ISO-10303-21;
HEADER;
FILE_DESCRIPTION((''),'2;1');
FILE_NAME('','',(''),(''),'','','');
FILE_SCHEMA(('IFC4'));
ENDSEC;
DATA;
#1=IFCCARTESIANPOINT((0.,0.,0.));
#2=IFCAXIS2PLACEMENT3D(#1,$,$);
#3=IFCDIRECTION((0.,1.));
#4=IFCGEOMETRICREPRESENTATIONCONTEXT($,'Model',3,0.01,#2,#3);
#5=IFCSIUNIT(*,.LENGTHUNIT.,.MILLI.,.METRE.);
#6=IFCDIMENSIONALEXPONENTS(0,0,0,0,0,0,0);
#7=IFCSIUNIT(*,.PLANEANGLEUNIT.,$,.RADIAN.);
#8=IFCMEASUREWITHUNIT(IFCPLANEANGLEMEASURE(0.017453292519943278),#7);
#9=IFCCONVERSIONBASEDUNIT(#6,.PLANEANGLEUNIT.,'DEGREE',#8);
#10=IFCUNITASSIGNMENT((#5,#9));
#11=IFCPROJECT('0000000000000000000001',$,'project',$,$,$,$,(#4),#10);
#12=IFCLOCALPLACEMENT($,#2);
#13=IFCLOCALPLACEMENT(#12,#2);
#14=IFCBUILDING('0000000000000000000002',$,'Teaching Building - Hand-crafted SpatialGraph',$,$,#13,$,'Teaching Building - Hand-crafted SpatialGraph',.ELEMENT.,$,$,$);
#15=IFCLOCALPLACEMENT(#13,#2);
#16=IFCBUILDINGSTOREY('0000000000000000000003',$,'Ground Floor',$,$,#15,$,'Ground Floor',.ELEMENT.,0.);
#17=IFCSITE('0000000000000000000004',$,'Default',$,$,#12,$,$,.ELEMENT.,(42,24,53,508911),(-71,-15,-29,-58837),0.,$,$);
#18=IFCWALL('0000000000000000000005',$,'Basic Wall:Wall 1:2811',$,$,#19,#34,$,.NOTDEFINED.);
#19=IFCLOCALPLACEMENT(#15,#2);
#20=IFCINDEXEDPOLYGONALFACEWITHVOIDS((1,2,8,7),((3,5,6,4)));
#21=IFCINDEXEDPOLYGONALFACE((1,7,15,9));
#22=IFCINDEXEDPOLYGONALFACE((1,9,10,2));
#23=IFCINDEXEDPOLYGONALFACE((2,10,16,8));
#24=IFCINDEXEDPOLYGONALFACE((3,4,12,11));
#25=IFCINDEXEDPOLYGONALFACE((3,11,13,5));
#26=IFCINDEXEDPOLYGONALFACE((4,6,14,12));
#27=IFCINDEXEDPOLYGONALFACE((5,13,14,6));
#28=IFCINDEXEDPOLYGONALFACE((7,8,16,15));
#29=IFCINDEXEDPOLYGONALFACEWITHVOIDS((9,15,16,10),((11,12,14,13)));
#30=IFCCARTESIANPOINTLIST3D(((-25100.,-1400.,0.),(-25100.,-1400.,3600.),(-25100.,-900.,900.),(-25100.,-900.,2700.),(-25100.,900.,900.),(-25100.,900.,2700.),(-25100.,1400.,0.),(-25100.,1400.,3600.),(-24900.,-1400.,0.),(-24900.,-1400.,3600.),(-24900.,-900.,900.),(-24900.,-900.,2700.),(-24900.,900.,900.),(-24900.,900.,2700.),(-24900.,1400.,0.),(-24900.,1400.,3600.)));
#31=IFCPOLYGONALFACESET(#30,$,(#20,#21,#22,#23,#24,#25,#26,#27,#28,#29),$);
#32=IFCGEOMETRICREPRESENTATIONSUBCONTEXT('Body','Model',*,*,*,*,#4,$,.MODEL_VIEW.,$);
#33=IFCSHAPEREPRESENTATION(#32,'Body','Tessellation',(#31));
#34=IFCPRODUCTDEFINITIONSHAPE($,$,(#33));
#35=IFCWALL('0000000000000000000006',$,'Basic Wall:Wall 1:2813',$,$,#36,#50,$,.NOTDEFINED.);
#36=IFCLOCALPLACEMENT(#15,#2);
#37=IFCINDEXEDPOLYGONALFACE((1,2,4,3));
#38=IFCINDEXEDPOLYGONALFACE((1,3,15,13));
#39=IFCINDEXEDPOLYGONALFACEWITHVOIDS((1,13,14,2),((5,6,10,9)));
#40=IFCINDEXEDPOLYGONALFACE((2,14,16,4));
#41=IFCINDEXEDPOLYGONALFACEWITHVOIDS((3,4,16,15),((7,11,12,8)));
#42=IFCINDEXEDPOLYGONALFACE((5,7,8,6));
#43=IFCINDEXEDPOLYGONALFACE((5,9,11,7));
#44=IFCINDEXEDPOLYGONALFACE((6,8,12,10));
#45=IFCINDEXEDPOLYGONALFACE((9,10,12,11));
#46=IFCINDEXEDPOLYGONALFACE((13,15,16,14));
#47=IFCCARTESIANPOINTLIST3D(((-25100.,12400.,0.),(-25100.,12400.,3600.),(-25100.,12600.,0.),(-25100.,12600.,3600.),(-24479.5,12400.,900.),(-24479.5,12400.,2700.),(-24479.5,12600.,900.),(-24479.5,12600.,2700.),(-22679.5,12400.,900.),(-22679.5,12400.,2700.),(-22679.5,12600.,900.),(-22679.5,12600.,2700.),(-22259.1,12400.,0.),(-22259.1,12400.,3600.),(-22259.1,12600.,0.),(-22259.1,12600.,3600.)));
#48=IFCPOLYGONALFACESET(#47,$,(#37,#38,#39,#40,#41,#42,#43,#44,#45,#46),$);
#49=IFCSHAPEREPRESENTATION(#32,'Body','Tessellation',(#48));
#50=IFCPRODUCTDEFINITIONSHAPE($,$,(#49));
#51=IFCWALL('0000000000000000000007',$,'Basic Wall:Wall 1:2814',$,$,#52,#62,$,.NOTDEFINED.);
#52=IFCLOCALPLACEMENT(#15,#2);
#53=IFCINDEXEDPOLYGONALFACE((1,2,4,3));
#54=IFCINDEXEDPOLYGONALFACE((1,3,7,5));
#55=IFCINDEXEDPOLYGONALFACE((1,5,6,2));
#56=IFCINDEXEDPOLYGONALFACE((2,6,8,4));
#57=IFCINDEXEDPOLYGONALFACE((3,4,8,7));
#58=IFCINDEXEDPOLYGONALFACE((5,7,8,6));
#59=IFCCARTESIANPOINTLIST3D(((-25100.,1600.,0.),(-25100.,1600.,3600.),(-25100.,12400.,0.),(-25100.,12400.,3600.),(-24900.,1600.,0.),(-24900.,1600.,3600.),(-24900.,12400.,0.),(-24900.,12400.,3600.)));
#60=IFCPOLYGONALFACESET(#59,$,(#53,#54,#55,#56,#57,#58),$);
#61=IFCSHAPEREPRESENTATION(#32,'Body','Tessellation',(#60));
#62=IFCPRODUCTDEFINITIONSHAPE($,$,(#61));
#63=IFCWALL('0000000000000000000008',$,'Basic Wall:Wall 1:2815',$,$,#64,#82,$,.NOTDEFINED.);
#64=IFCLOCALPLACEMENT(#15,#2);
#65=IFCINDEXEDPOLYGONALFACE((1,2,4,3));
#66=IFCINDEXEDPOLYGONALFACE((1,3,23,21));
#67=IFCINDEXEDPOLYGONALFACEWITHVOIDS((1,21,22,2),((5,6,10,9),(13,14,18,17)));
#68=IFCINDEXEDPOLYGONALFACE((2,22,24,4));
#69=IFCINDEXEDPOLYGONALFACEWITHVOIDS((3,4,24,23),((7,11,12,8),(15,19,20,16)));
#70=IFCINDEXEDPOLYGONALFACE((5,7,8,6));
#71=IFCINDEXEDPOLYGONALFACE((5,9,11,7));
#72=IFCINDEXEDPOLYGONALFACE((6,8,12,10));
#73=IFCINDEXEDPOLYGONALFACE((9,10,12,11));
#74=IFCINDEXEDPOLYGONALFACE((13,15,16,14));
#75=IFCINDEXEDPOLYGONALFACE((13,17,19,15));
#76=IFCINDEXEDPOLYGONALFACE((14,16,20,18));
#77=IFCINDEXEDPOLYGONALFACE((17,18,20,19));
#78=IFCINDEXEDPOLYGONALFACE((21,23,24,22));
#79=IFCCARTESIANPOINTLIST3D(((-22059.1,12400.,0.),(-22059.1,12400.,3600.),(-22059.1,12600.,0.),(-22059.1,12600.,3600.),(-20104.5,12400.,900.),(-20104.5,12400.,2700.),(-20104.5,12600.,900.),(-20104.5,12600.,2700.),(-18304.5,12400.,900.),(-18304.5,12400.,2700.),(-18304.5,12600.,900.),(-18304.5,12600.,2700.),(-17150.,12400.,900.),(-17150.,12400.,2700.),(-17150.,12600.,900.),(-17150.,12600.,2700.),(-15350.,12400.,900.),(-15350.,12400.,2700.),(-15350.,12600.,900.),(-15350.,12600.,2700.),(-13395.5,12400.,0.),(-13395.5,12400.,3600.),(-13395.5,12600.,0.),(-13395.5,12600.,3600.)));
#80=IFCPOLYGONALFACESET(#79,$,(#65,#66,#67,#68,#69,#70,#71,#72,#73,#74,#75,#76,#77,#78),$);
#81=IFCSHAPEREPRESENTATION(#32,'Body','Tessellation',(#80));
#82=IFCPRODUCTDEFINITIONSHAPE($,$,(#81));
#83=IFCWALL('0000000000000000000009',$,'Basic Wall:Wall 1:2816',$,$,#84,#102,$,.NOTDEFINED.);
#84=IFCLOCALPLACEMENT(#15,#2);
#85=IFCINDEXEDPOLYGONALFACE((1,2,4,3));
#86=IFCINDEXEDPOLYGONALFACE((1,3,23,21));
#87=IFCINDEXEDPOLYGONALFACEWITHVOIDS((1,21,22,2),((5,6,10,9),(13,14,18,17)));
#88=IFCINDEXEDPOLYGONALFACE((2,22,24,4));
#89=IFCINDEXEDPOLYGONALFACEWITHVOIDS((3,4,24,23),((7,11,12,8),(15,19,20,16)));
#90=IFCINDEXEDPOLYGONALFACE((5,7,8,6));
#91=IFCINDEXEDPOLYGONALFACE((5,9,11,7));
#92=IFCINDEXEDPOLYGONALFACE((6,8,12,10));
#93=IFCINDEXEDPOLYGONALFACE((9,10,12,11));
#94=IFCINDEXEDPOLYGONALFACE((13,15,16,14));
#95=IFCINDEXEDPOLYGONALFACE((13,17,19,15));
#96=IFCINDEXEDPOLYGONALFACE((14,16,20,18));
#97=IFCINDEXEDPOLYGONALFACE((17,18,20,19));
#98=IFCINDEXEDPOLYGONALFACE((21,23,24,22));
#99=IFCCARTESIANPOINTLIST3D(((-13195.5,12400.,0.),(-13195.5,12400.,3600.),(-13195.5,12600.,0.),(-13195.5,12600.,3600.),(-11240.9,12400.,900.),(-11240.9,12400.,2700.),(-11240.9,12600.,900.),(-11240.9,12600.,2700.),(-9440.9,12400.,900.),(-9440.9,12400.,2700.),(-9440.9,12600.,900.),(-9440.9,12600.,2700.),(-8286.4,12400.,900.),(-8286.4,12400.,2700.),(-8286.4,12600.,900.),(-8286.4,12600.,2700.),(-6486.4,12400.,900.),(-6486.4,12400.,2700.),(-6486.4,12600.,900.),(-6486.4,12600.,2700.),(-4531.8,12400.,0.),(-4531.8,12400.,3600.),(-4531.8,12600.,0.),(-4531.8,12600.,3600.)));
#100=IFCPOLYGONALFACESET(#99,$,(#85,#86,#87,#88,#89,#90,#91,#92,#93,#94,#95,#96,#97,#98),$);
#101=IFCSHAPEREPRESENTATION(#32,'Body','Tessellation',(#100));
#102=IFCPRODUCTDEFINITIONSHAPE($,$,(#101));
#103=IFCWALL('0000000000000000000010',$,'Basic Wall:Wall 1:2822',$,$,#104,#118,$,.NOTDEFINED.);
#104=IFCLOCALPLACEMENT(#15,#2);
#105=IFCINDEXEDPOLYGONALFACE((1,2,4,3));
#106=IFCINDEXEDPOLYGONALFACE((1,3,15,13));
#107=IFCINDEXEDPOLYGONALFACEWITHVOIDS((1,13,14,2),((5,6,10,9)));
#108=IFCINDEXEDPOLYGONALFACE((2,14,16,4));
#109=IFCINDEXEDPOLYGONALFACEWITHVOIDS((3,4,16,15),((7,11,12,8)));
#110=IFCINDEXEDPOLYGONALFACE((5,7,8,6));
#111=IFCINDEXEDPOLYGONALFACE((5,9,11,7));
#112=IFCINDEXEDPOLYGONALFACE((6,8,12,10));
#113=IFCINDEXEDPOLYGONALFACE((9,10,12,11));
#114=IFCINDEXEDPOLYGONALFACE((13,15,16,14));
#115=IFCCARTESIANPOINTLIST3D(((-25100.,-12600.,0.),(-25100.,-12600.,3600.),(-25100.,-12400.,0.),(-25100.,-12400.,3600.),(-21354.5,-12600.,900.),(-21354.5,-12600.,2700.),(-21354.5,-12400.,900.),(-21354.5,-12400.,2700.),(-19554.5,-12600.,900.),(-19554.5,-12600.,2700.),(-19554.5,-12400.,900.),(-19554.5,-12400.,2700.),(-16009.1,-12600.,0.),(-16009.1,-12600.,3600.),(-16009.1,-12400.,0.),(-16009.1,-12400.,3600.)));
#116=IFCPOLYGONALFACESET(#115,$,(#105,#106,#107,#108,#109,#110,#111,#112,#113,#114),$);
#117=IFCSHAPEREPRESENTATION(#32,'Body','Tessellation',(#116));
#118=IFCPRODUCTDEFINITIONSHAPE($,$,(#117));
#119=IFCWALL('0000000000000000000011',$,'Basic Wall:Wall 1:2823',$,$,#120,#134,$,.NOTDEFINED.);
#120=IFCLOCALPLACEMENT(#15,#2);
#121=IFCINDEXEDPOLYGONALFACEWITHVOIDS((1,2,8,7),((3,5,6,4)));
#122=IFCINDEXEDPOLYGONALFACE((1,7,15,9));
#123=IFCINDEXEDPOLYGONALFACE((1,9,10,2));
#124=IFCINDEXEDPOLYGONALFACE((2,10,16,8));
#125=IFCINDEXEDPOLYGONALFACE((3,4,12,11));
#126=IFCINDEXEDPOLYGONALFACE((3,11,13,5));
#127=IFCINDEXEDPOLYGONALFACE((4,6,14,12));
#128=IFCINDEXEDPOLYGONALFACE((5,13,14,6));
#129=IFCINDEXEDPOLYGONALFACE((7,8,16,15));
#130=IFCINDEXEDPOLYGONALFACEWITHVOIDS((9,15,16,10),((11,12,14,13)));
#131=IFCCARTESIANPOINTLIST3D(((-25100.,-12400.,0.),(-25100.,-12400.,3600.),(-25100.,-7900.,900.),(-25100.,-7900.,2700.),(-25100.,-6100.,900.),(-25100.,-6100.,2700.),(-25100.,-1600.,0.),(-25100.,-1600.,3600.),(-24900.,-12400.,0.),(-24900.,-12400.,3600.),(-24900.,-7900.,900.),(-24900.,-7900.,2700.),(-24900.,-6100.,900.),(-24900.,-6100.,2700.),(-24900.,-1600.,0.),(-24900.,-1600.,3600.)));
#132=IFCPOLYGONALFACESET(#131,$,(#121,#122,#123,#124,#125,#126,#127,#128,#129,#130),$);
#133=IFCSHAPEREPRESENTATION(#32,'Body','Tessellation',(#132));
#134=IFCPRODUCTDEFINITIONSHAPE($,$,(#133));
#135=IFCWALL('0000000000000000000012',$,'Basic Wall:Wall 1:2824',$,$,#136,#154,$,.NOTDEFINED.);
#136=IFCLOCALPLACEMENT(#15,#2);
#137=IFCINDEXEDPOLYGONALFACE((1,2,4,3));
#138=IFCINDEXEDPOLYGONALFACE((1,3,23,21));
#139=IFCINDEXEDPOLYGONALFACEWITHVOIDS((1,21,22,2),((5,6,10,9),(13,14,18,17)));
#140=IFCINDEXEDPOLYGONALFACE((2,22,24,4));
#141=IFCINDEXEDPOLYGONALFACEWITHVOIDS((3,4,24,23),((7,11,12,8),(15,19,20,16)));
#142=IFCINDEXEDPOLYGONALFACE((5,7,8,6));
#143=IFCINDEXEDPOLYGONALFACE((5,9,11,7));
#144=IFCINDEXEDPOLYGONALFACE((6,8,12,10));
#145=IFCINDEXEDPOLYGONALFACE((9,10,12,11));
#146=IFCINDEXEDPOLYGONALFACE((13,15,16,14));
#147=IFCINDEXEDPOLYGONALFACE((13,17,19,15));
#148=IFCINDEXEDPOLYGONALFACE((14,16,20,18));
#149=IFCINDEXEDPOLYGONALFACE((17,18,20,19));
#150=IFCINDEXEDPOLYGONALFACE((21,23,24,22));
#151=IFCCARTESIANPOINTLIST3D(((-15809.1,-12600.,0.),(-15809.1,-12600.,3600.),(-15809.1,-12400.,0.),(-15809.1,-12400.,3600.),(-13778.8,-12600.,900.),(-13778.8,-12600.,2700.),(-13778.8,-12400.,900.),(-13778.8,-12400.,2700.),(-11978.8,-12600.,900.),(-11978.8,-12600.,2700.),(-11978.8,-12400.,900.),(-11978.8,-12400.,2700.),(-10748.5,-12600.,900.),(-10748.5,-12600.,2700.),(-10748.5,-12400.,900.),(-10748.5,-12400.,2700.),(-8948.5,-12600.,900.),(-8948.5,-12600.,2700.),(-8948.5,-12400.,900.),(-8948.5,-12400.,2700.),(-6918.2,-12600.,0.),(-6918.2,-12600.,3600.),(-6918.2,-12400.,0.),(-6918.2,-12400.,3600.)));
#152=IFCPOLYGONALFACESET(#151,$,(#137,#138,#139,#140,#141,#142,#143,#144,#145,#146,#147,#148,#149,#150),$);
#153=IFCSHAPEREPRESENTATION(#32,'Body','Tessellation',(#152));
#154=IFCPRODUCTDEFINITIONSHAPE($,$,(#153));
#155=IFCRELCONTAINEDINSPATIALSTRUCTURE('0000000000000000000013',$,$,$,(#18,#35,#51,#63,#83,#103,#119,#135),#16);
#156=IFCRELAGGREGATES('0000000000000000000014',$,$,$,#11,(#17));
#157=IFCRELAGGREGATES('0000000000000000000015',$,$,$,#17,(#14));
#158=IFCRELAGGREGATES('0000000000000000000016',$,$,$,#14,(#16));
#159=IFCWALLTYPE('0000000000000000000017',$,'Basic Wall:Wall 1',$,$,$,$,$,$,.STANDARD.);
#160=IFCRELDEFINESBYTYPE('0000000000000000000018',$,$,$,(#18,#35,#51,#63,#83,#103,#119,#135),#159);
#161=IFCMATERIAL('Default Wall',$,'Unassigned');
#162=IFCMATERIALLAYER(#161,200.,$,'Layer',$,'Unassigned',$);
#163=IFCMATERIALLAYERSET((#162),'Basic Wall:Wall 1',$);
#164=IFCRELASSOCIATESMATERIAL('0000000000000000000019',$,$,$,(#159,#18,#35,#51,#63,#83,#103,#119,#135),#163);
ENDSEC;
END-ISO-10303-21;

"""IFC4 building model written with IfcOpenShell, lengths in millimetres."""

from ifc_helpers import new_model, entity, si_unit, converted_unit, direction, frame, frame_2d, origin, origin_2d_with_axis, place, context, subcontext, project, spatial, rectangle, extrude, material, layer, layer_set, layer_usage, type_object, element, save


model = new_model("IFC4")

# Units and contexts
model_context = context("Model", 3, precision=0.01, world=origin(), true_north=direction((0.0, 1.0)))
body_context = subcontext(model_context, "Body", "Model", "MODEL_VIEW")
ifc_project = project(units=[si_unit("LENGTHUNIT", "METRE", prefix="MILLI"), converted_unit("PLANEANGLEUNIT", "DEGREE", entity("IfcPlaneAngleMeasure", 0.017453292519943278), si_unit("PLANEANGLEUNIT", "RADIAN"), dimensions=[0, 0, 0, 0, 0, 0, 0])], contexts=[model_context])

# Site, building, storey
site_placement = place(None, origin())
site = spatial("IfcSite", under=ifc_project, at=site_placement, Name="Default", CompositionType="ELEMENT", RefLatitude=(42, 24, 53, 508911), RefLongitude=(-71, -15, -29, -58837), RefElevation=0.0)
building_placement = place(site_placement, origin())
building = spatial("IfcBuilding", under=site, at=building_placement, Name="Teaching Building - Hand-crafted SpatialGraph", LongName="Teaching Building - Hand-crafted SpatialGraph", CompositionType="ELEMENT")
storey_placement = place(building_placement, origin())
storey = spatial("IfcBuildingStorey", under=building, at=storey_placement, Name="Ground Floor", LongName="Ground Floor", CompositionType="ELEMENT", Elevation=0.0)

# Shared definitions
ifc_material = material(Name="Default Wall", Category="Unassigned")
ifc_layer = layer(ifc_material, 200.0, Name="Layer", Category="Unassigned")
ifc_layer_set = layer_set([ifc_layer], Name="Basic Wall:Wall 1")
wall_type = type_object("IfcWallType", Name="Basic Wall:Wall 1", PredefinedType="STANDARD", material=ifc_layer_set)

# Walls, openings
ifc_layer_usage_1 = layer_usage(ifc_layer_set, "AXIS2", "NEGATIVE", 100.0)
wall_1_placement = place(storey_placement, frame((-25000.0, -1400.0, 0.0), z_axis=(0.0, 0.0, 1.0), x_axis=(0.0, 1.0, 0.0)))
wall_1 = element("IfcWall", 1, at=wall_1_placement, inside=storey, type_object=wall_type, material=ifc_layer_usage_1, Name="Basic Wall:Wall 1:2811", PredefinedType="NOTDEFINED", context=body_context, shape_type="SweptSolid", body=[
    extrude(rectangle(XDim=2800.0, YDim=200.0, at=frame_2d((1400.0, 0.0), x_axis=(-1.0, 0.0))), origin(), (0.0, 0.0, 1.0), 3600.0),
])
opening_1_placement = place(wall_1_placement, origin())
element("IfcOpeningElement", 2, at=opening_1_placement, cuts=wall_1, PredefinedType="OPENING", context=body_context, shape_type="SweptSolid", body=[
    extrude(rectangle(XDim=1800.0, YDim=1800.0, at=origin_2d_with_axis()), frame((1400.0, -100.0, 1800.0), z_axis=(0.0, 1.0, 0.0), x_axis=(0.0, 0.0, -1.0)), (0.0, 0.0, 1.0), 200.0),
])
ifc_layer_usage_2 = layer_usage(ifc_layer_set, "AXIS2", "NEGATIVE", 100.0)
wall_2_placement = place(storey_placement, frame((-25100.0, 12500.0, 0.0)))
wall_2 = element("IfcWall", 3, at=wall_2_placement, inside=storey, type_object=wall_type, material=ifc_layer_usage_2, Name="Basic Wall:Wall 1:2813", PredefinedType="NOTDEFINED", context=body_context, shape_type="SweptSolid", body=[
    extrude(rectangle(XDim=2840.9, YDim=200.0, at=frame_2d((1420.5, 0.0), x_axis=(-1.0, 0.0))), origin(), (0.0, 0.0, 1.0), 3600.0),
])
opening_2_placement = place(wall_2_placement, origin())
element("IfcOpeningElement", 4, at=opening_2_placement, cuts=wall_2, PredefinedType="OPENING", context=body_context, shape_type="SweptSolid", body=[
    extrude(rectangle(XDim=1800.0, YDim=1800.0, at=frame_2d((0.0, 0.0), x_axis=(1.0, 0.0))), frame((1520.5, -100.0, 1800.0), z_axis=(0.0, 1.0, 0.0), x_axis=(0.0, 0.0, -1.0)), (0.0, 0.0, 1.0), 200.0),
])

# Wall
ifc_layer_usage_3 = layer_usage(ifc_layer_set, "AXIS2", "NEGATIVE", 100.0)
wall_3_placement = place(storey_placement, frame((-25000.0, 1600.0, 0.0), z_axis=(0.0, 0.0, 1.0), x_axis=(0.0, 1.0, 0.0)))
element("IfcWall", 5, at=wall_3_placement, inside=storey, type_object=wall_type, material=ifc_layer_usage_3, Name="Basic Wall:Wall 1:2814", PredefinedType="NOTDEFINED", context=body_context, shape_type="SweptSolid", body=[
    extrude(rectangle(XDim=10800.0, YDim=200.0, at=frame_2d((5400.0, 0.0), x_axis=(-1.0, 0.0))), origin(), (0.0, 0.0, 1.0), 3600.0),
])

# Walls, openings
ifc_layer_usage_4 = layer_usage(ifc_layer_set, "AXIS2", "NEGATIVE", 100.0)
wall_4_placement = place(storey_placement, frame((-22059.1, 12500.0, 0.0)))
wall_4 = element("IfcWall", 6, at=wall_4_placement, inside=storey, type_object=wall_type, material=ifc_layer_usage_4, Name="Basic Wall:Wall 1:2815", PredefinedType="NOTDEFINED", context=body_context, shape_type="SweptSolid", body=[
    extrude(rectangle(XDim=8663.6, YDim=200.0, at=frame_2d((4331.8, 0.0), x_axis=(-1.0, 0.0))), origin(), (0.0, 0.0, 1.0), 3600.0),
])
opening_3_placement = place(wall_4_placement, origin())
element("IfcOpeningElement", 7, at=opening_3_placement, cuts=wall_4, PredefinedType="OPENING", context=body_context, shape_type="SweptSolid", body=[
    extrude(rectangle(XDim=1800.0, YDim=1800.0, at=origin_2d_with_axis()), frame((2854.5, -100.0, 1800.0), z_axis=(0.0, 1.0, 0.0), x_axis=(0.0, 0.0, -1.0)), (0.0, 0.0, 1.0), 200.0),
])
opening_4_placement = place(wall_4_placement, origin())
element("IfcOpeningElement", 8, at=opening_4_placement, cuts=wall_4, PredefinedType="OPENING", context=body_context, shape_type="SweptSolid", body=[
    extrude(rectangle(XDim=1800.0, YDim=1800.0, at=frame_2d((0.0, 0.0), x_axis=(1.0, 0.0))), frame((5809.1, -100.0, 1800.0), z_axis=(0.0, 1.0, 0.0), x_axis=(0.0, 0.0, -1.0)), (0.0, 0.0, 1.0), 200.0),
])
ifc_layer_usage_5 = layer_usage(ifc_layer_set, "AXIS2", "NEGATIVE", 100.0)
wall_5_placement = place(storey_placement, frame((-13195.5, 12500.0, 0.0)))
wall_5 = element("IfcWall", 9, at=wall_5_placement, inside=storey, type_object=wall_type, material=ifc_layer_usage_5, Name="Basic Wall:Wall 1:2816", PredefinedType="NOTDEFINED", context=body_context, shape_type="SweptSolid", body=[
    extrude(rectangle(XDim=8663.6, YDim=200.0, at=frame_2d((4331.8, 0.0), x_axis=(-1.0, 0.0))), origin(), (0.0, 0.0, 1.0), 3600.0),
])
opening_5_placement = place(wall_5_placement, origin())
element("IfcOpeningElement", 10, at=opening_5_placement, cuts=wall_5, PredefinedType="OPENING", context=body_context, shape_type="SweptSolid", body=[
    extrude(rectangle(XDim=1800.0, YDim=1800.0, at=frame_2d((0.0, 0.0), x_axis=(1.0, 0.0))), frame((2854.5, -100.0, 1800.0), z_axis=(0.0, 1.0, 0.0), x_axis=(0.0, 0.0, -1.0)), (0.0, 0.0, 1.0), 200.0),
])
opening_6_placement = place(wall_5_placement, origin())
element("IfcOpeningElement", 11, at=opening_6_placement, cuts=wall_5, PredefinedType="OPENING", context=body_context, shape_type="SweptSolid", body=[
    extrude(rectangle(XDim=1800.0, YDim=1800.0, at=origin_2d_with_axis()), frame((5809.1, -100.0, 1800.0), z_axis=(0.0, 1.0, 0.0), x_axis=(0.0, 0.0, -1.0)), (0.0, 0.0, 1.0), 200.0),
])

# Walls, openings
ifc_layer_usage_6 = layer_usage(ifc_layer_set, "AXIS2", "NEGATIVE", 100.0)
wall_6_placement = place(storey_placement, frame((-25100.0, -12500.0, 0.0)))
wall_6 = element("IfcWall", 12, at=wall_6_placement, inside=storey, type_object=wall_type, material=ifc_layer_usage_6, Name="Basic Wall:Wall 1:2822", PredefinedType="NOTDEFINED", context=body_context, shape_type="SweptSolid", body=[
    extrude(rectangle(XDim=9090.9, YDim=200.0, at=frame_2d((4545.5, 0.0), x_axis=(-1.0, 0.0))), origin(), (0.0, 0.0, 1.0), 3600.0),
])
opening_7_placement = place(wall_6_placement, origin())
element("IfcOpeningElement", 13, at=opening_7_placement, cuts=wall_6, PredefinedType="OPENING", context=body_context, shape_type="SweptSolid", body=[
    extrude(rectangle(XDim=1800.0, YDim=1800.0, at=frame_2d((0.0, 0.0), x_axis=(1.0, 0.0))), frame((4645.5, -100.0, 1800.0), z_axis=(0.0, 1.0, 0.0), x_axis=(0.0, 0.0, -1.0)), (0.0, 0.0, 1.0), 200.0),
])
ifc_layer_usage_7 = layer_usage(ifc_layer_set, "AXIS2", "NEGATIVE", 100.0)
wall_7_placement = place(storey_placement, frame((-25000.0, -12400.0, 0.0), z_axis=(0.0, 0.0, 1.0), x_axis=(0.0, 1.0, 0.0)))
wall_7 = element("IfcWall", 14, at=wall_7_placement, inside=storey, type_object=wall_type, material=ifc_layer_usage_7, Name="Basic Wall:Wall 1:2823", PredefinedType="NOTDEFINED", context=body_context, shape_type="SweptSolid", body=[
    extrude(rectangle(XDim=10800.0, YDim=200.0, at=frame_2d((5400.0, 0.0), x_axis=(-1.0, 0.0))), origin(), (0.0, 0.0, 1.0), 3600.0),
])
opening_8_placement = place(wall_7_placement, origin())
element("IfcOpeningElement", 15, at=opening_8_placement, cuts=wall_7, PredefinedType="OPENING", context=body_context, shape_type="SweptSolid", body=[
    extrude(rectangle(XDim=1800.0, YDim=1800.0, at=origin_2d_with_axis()), frame((5400.0, -100.0, 1800.0), z_axis=(0.0, 1.0, 0.0), x_axis=(0.0, 0.0, -1.0)), (0.0, 0.0, 1.0), 200.0),
])

# Wall, openings
ifc_layer_usage_8 = layer_usage(ifc_layer_set, "AXIS2", "NEGATIVE", 100.0)
wall_8_placement = place(storey_placement, frame((-15809.1, -12500.0, 0.0)))
wall_8 = element("IfcWall", 16, at=wall_8_placement, inside=storey, type_object=wall_type, material=ifc_layer_usage_8, Name="Basic Wall:Wall 1:2824", PredefinedType="NOTDEFINED", context=body_context, shape_type="SweptSolid", body=[
    extrude(rectangle(XDim=8890.9, YDim=200.0, at=frame_2d((4445.5, 0.0), x_axis=(-1.0, 0.0))), origin(), (0.0, 0.0, 1.0), 3600.0),
])
opening_9_placement = place(wall_8_placement, origin())
element("IfcOpeningElement", 17, at=opening_9_placement, cuts=wall_8, PredefinedType="OPENING", context=body_context, shape_type="SweptSolid", body=[
    extrude(rectangle(XDim=1800.0, YDim=1800.0, at=frame_2d((0.0, 0.0), x_axis=(1.0, 0.0))), frame((2930.3, -100.0, 1800.0), z_axis=(0.0, 1.0, 0.0), x_axis=(0.0, 0.0, -1.0)), (0.0, 0.0, 1.0), 200.0),
])
opening_10_placement = place(wall_8_placement, origin())
element("IfcOpeningElement", 18, at=opening_10_placement, cuts=wall_8, PredefinedType="OPENING", context=body_context, shape_type="SweptSolid", body=[
    extrude(rectangle(XDim=1800.0, YDim=1800.0, at=frame_2d((0.0, 0.0), x_axis=(1.0, 0.0))), frame((5960.6, -100.0, 1800.0), z_axis=(0.0, 1.0, 0.0), x_axis=(0.0, 0.0, -1.0)), (0.0, 0.0, 1.0), 200.0),
])

save(model, "model.ifc")
